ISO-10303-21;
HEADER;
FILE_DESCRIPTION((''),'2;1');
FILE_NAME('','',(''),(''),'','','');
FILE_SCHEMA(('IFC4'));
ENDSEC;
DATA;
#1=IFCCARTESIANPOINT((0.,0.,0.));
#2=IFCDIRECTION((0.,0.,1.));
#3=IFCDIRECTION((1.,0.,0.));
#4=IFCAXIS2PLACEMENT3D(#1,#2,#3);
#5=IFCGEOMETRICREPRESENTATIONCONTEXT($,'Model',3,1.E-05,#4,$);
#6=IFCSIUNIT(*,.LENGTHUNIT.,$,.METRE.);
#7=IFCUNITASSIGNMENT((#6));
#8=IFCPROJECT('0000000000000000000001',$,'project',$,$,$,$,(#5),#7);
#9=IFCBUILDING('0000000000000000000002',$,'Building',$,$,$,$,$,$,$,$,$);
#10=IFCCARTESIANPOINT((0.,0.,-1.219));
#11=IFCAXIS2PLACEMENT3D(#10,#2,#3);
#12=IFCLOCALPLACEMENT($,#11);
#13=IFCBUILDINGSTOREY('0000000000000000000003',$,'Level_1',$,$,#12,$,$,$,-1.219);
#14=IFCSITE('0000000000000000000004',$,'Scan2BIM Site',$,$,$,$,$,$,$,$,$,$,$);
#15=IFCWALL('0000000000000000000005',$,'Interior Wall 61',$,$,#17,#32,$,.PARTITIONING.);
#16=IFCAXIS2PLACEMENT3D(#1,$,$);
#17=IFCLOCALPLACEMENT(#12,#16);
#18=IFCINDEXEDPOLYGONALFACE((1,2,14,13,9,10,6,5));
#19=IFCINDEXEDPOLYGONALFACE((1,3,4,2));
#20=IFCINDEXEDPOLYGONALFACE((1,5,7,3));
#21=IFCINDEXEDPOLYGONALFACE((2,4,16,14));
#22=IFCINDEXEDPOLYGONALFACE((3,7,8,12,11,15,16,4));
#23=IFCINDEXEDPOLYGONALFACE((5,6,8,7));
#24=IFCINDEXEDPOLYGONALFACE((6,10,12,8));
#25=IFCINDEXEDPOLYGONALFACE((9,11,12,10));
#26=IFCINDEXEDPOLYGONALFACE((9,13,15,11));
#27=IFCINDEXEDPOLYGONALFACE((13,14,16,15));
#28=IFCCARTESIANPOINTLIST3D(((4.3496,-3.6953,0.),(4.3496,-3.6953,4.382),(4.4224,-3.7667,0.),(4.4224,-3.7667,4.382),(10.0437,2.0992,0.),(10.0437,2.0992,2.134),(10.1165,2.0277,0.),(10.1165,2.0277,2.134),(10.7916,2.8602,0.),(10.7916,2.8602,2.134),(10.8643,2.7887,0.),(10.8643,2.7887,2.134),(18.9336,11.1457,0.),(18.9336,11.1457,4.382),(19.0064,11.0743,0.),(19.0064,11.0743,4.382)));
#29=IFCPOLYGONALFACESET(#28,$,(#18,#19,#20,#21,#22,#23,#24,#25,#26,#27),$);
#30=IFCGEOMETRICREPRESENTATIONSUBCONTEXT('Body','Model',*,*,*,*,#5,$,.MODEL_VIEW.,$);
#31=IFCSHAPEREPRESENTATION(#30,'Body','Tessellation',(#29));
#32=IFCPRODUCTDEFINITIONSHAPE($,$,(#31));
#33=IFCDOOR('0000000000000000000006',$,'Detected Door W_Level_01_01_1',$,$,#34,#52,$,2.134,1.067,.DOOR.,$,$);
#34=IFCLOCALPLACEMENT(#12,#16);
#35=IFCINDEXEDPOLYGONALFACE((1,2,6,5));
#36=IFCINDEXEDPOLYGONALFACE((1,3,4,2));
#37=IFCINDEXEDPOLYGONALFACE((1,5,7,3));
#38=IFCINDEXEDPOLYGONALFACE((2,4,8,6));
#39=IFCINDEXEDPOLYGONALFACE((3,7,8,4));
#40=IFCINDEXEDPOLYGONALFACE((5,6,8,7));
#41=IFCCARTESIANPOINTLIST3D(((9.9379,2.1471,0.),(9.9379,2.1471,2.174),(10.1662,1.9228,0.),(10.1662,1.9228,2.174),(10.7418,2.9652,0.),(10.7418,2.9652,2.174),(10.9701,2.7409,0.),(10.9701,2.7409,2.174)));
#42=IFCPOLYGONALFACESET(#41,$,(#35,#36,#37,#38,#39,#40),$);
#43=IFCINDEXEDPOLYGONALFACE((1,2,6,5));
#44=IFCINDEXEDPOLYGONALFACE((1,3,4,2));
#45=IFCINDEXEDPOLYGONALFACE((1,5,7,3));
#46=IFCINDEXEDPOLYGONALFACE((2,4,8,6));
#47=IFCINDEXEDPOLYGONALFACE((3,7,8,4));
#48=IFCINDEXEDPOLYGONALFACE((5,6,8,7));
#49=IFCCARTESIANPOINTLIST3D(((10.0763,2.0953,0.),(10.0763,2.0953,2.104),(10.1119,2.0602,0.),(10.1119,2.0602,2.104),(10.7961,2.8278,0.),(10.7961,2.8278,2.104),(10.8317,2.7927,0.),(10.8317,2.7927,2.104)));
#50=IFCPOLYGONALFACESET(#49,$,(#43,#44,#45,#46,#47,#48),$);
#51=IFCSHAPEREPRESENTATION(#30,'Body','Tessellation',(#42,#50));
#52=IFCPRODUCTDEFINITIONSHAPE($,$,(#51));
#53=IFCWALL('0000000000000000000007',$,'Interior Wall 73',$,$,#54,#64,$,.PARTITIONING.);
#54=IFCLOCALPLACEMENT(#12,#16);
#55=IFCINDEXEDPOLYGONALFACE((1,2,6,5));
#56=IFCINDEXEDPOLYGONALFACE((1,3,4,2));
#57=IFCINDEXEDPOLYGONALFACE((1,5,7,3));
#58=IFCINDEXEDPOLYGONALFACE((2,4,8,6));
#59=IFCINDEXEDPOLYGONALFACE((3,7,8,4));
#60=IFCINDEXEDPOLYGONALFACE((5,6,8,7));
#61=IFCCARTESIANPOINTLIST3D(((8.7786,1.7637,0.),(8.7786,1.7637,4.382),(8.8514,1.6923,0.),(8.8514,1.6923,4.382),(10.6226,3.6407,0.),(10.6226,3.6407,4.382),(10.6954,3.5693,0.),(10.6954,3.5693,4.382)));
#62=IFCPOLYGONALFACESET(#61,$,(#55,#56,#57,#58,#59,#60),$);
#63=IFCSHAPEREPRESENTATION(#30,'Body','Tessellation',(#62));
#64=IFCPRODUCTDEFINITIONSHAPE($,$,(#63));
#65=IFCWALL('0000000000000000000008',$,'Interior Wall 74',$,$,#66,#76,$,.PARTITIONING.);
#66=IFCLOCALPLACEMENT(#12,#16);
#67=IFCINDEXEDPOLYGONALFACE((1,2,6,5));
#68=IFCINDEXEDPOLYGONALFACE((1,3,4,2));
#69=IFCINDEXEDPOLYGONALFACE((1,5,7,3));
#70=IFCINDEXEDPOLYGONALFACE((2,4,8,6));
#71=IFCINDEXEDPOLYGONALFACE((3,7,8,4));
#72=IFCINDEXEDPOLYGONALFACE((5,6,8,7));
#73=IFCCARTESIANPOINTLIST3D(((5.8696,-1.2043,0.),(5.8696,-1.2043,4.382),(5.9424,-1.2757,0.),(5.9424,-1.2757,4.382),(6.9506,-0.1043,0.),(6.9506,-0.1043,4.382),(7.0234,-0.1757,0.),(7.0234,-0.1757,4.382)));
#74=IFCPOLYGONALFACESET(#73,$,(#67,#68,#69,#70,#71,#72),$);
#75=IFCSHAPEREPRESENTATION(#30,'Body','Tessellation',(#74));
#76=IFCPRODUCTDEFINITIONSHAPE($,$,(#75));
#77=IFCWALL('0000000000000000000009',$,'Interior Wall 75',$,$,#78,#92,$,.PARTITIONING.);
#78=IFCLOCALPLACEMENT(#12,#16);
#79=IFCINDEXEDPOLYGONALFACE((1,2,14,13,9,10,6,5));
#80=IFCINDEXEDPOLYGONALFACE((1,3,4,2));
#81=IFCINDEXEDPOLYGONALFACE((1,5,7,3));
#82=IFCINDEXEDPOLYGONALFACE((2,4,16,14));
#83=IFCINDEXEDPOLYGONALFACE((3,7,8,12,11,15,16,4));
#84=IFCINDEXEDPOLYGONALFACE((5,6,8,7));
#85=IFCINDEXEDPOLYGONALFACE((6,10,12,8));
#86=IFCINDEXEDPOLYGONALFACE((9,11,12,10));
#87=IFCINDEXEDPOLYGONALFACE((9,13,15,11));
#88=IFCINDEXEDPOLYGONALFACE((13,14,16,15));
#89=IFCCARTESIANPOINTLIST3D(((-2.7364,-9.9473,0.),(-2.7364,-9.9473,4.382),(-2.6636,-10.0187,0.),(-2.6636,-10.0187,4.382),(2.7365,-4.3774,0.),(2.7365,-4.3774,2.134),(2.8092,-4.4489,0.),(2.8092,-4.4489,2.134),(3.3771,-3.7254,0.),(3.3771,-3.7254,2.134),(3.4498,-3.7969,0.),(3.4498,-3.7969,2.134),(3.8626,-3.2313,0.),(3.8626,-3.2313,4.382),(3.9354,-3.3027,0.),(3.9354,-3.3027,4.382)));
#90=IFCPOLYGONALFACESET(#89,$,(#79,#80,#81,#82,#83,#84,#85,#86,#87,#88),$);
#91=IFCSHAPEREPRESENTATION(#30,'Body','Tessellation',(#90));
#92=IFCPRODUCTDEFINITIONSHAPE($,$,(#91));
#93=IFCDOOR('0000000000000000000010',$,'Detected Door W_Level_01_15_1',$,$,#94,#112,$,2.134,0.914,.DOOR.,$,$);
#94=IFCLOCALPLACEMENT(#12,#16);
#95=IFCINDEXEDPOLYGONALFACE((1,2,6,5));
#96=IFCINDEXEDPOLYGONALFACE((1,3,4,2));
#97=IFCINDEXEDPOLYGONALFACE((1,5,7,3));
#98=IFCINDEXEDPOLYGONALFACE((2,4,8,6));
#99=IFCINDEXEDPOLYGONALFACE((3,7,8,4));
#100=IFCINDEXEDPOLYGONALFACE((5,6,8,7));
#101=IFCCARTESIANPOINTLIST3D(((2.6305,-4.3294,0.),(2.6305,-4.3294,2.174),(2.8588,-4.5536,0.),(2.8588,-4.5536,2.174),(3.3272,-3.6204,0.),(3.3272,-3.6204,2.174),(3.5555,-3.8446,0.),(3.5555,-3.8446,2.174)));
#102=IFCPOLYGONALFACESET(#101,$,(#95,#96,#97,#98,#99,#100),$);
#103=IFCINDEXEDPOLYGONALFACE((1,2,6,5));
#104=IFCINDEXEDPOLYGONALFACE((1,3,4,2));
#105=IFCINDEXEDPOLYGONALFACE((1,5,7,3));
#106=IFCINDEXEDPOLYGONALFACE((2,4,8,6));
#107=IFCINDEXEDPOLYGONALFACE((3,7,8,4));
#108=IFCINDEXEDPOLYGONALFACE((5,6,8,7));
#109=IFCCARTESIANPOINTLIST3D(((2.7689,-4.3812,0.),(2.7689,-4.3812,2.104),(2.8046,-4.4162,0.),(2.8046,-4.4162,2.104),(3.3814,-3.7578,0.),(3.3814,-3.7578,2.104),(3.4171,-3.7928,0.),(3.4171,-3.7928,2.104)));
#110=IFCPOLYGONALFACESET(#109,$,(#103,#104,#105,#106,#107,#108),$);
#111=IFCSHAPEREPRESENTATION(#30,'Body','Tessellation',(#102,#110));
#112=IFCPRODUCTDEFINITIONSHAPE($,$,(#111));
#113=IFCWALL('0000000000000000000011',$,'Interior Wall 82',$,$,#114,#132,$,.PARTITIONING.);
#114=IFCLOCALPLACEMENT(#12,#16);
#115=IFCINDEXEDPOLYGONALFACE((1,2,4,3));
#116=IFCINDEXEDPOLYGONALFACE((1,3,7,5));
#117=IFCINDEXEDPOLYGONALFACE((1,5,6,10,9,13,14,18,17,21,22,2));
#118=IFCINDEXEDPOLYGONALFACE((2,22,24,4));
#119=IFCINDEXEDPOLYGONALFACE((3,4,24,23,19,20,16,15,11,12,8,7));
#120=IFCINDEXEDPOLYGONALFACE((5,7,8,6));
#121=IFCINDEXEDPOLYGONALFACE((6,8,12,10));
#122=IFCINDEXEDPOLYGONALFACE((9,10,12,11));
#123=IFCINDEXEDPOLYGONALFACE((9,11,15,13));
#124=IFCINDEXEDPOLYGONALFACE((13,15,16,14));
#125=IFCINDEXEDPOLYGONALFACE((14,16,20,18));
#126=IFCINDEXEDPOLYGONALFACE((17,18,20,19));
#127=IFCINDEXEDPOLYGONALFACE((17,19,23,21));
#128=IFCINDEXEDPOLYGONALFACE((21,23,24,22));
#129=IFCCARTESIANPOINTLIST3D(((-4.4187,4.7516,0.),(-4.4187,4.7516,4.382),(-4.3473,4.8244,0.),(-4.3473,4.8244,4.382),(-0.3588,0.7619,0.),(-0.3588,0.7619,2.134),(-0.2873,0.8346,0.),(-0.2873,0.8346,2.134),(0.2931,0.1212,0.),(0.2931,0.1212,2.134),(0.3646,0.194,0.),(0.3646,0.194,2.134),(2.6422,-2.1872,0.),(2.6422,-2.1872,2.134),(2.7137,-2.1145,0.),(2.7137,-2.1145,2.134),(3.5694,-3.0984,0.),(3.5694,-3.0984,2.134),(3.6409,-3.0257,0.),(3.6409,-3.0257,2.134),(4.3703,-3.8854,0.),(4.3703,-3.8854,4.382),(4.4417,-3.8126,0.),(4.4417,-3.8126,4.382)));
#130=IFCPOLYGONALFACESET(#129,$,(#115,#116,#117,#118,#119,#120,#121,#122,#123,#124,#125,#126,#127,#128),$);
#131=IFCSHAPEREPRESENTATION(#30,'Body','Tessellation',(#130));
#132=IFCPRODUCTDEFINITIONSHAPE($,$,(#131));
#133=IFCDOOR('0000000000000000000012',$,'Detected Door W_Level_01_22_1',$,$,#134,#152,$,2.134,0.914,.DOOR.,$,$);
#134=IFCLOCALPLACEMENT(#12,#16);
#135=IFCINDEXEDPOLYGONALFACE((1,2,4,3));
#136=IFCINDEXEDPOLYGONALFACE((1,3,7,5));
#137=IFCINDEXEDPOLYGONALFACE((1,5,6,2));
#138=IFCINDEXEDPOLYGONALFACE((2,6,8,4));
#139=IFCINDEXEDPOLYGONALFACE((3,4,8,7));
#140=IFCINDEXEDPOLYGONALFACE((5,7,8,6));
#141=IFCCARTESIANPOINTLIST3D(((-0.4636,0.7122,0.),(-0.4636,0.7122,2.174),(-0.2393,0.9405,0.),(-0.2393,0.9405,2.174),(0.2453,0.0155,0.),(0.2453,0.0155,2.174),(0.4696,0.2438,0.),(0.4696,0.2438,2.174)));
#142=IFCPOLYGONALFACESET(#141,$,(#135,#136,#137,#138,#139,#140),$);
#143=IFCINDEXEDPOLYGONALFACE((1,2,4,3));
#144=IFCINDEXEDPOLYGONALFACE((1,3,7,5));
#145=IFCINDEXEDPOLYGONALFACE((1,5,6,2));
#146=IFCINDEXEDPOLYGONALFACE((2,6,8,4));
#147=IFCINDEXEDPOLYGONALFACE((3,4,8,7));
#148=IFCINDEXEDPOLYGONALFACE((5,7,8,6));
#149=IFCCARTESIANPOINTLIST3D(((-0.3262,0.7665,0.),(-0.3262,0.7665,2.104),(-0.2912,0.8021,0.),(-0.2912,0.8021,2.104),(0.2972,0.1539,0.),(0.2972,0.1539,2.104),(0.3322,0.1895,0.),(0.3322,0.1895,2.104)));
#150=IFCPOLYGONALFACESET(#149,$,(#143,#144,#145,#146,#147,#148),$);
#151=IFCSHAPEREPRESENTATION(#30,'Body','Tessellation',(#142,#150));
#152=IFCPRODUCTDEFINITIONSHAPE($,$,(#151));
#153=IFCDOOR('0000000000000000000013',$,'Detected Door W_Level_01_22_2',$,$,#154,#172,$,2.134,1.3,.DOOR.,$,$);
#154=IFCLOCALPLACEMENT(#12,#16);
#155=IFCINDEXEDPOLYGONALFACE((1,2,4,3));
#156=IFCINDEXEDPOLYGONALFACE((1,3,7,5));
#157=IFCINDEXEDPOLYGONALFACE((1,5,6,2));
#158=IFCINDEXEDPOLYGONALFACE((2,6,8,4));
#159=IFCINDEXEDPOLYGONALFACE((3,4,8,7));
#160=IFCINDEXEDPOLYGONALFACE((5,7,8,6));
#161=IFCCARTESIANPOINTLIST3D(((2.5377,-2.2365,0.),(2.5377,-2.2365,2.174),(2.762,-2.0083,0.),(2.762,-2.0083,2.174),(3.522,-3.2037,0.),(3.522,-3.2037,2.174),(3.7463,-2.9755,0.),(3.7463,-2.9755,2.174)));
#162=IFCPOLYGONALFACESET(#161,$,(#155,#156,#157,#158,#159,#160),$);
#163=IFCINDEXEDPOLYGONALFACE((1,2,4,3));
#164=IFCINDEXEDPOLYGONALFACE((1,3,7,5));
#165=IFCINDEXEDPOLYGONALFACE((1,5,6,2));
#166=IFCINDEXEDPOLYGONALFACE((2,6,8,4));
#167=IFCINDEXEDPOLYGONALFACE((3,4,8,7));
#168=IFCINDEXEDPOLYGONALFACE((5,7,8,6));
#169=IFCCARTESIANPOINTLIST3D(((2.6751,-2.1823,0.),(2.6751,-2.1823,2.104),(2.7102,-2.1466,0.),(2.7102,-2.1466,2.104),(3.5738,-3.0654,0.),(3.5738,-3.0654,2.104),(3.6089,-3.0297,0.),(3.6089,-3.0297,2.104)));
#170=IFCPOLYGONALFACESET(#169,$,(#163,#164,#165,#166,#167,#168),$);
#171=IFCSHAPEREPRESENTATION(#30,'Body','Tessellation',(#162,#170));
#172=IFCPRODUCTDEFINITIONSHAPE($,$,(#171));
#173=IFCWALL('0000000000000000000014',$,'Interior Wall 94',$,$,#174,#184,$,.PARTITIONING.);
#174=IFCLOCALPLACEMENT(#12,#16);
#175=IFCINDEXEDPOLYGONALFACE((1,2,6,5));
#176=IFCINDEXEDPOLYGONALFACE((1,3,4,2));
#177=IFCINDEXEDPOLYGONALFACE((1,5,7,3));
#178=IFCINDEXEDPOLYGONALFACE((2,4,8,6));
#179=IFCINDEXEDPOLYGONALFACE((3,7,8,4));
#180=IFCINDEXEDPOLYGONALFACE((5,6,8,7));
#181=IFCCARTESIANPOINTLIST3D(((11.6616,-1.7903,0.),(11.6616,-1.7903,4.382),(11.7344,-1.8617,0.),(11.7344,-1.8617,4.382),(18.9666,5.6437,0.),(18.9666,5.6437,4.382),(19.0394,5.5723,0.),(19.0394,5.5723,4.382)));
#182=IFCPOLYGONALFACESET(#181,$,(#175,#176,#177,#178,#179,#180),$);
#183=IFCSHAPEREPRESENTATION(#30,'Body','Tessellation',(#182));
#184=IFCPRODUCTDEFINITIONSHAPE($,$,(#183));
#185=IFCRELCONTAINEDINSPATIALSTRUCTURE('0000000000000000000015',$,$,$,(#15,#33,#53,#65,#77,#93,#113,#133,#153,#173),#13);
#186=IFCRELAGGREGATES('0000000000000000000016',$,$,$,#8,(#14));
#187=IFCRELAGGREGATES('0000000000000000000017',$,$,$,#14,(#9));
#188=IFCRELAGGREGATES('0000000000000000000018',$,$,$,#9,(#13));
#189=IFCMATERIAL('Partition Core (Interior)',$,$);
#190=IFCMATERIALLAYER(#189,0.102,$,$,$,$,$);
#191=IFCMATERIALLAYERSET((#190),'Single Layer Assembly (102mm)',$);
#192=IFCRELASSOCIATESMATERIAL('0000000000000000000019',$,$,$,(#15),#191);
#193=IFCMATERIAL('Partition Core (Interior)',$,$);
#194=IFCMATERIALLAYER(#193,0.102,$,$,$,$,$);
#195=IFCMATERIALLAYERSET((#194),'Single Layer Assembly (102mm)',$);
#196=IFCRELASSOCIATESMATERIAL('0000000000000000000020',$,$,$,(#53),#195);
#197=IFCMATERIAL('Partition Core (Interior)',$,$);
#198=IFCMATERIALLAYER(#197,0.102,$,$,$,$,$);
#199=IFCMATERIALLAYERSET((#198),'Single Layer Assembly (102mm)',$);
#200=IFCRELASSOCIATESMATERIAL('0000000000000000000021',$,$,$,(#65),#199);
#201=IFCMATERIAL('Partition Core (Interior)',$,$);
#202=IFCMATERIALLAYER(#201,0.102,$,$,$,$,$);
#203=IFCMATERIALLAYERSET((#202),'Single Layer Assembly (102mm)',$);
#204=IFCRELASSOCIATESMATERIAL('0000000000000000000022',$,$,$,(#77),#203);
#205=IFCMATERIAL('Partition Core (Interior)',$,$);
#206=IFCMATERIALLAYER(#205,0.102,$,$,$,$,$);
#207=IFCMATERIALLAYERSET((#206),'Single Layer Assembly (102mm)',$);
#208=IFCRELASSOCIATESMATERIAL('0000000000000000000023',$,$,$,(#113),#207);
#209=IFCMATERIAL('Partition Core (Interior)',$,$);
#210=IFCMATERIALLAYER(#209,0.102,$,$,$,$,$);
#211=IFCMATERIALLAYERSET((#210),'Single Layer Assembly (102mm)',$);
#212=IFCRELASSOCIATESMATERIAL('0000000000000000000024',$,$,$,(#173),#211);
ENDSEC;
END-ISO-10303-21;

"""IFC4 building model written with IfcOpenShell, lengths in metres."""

from ifc_helpers import new_model, si_unit, frame, origin, origin_with_axes, place, context, subcontext, project, spatial, rectangle, extrude, material, layer, layer_set, element, fill, save


model = new_model("IFC4")

# Units and contexts
model_context = context("Model", 3, precision=1e-05, world=origin_with_axes())
body_context = subcontext(model_context, "Body", "Model", "MODEL_VIEW")
ifc_project = project(units=[si_unit("LENGTHUNIT", "METRE")], contexts=[model_context])

# Site, building, storey
site = spatial("IfcSite", under=ifc_project, Name="Scan2BIM Site")
building = spatial("IfcBuilding", under=site, Name="Building")
storey_placement = place(None, frame((0.0, 0.0, -1.219), z_axis=(0.0, 0.0, 1.0), x_axis=(1.0, 0.0, 0.0)))
storey = spatial("IfcBuildingStorey", under=building, at=storey_placement, Name="Level_1", Elevation=-1.219)

# Wall, opening, door
ifc_material_1 = material(Name="Partition Core (Interior)")
ifc_layer_1 = layer(ifc_material_1, 0.102)
ifc_layer_set_1 = layer_set([ifc_layer_1], Name="Single Layer Assembly (102mm)")
wall_1_placement = place(storey_placement, frame((11.678, 3.6895, 0.0), z_axis=(0.0, 0.0, 1.0), x_axis=(-0.700904, -0.713255, 0.0)))
wall_1 = element("IfcWall", 1, at=wall_1_placement, inside=storey, material=ifc_layer_set_1, Name="Interior Wall 61", PredefinedType="PARTITIONING", context=body_context, shape_type="SweptSolid", body=[
    extrude(rectangle(XDim=20.8074, YDim=0.102), origin(), (0.0, 0.0, 1.0), 4.382),
])
opening_1_placement = place(None, frame((10.454, 2.444, -1.219), z_axis=(0.0, 0.0, 1.0), x_axis=(-0.700904, -0.713255, 0.0)))
opening_1 = element("IfcOpeningElement", 2, at=opening_1_placement, cuts=wall_1, PredefinedType="OPENING", context=body_context, shape_type="SweptSolid", body=[
    extrude(rectangle(XDim=1.067, YDim=0.202), origin(), (0.0, 0.0, 1.0), 2.134),
])
door_1_placement = place(opening_1_placement, frame((0.0, 0.0, 0.0), z_axis=(0.0, 0.0, 1.0), x_axis=(1.0, 0.0, 0.0)))
door_1 = element("IfcDoor", 3, at=door_1_placement, inside=storey, Name="Detected Door W_Level_01_01_1", OverallHeight=2.134, OverallWidth=1.067, PredefinedType="DOOR", context=body_context, shape_type="SweptSolid", body=[
    extrude(rectangle(XDim=1.147, YDim=0.32), origin(), (0.0, 0.0, 1.0), 2.174),
    extrude(rectangle(XDim=1.027, YDim=0.05), origin(), (0.0, 0.0, 1.0), 2.104),
])
fill(opening_1, door_1)

# Walls
ifc_material_2 = material(Name="Partition Core (Interior)")
ifc_layer_2 = layer(ifc_material_2, 0.102)
ifc_layer_set_2 = layer_set([ifc_layer_2], Name="Single Layer Assembly (102mm)")
wall_2_placement = place(storey_placement, frame((9.737, 2.6665, 0.0), z_axis=(0.0, 0.0, 1.0), x_axis=(-0.700808, -0.71335, 0.0)))
element("IfcWall", 4, at=wall_2_placement, inside=storey, material=ifc_layer_set_2, Name="Interior Wall 73", PredefinedType="PARTITIONING", context=body_context, shape_type="SweptSolid", body=[
    extrude(rectangle(XDim=2.6312, YDim=0.102), origin(), (0.0, 0.0, 1.0), 4.382),
])
ifc_material_3 = material(Name="Partition Core (Interior)")
ifc_layer_3 = layer(ifc_material_3, 0.102)
ifc_layer_set_3 = layer_set([ifc_layer_3], Name="Single Layer Assembly (102mm)")
wall_3_placement = place(storey_placement, frame((6.4465, -0.69, 0.0), z_axis=(0.0, 0.0, 1.0), x_axis=(-0.70092, -0.71324, 0.0)))
element("IfcWall", 5, at=wall_3_placement, inside=storey, material=ifc_layer_set_3, Name="Interior Wall 74", PredefinedType="PARTITIONING", context=body_context, shape_type="SweptSolid", body=[
    extrude(rectangle(XDim=1.5423, YDim=0.102), origin(), (0.0, 0.0, 1.0), 4.382),
])

# Wall, opening, door
ifc_material_4 = material(Name="Partition Core (Interior)")
ifc_layer_4 = layer(ifc_material_4, 0.102)
ifc_layer_set_4 = layer_set([ifc_layer_4], Name="Single Layer Assembly (102mm)")
wall_4_placement = place(storey_placement, frame((0.5995, -6.625, 0.0), z_axis=(0.0, 0.0, 1.0), x_axis=(-0.700866, -0.713293, 0.0)))
wall_4 = element("IfcWall", 6, at=wall_4_placement, inside=storey, material=ifc_layer_set_4, Name="Interior Wall 75", PredefinedType="PARTITIONING", context=body_context, shape_type="SweptSolid", body=[
    extrude(rectangle(XDim=9.4155, YDim=0.102), origin(), (0.0, 0.0, 1.0), 4.382),
])
opening_2_placement = place(None, frame((3.093, -4.087, -1.219), z_axis=(0.0, 0.0, 1.0), x_axis=(-0.700866, -0.713293, 0.0)))
opening_2 = element("IfcOpeningElement", 7, at=opening_2_placement, cuts=wall_4, PredefinedType="OPENING", context=body_context, shape_type="SweptSolid", body=[
    extrude(rectangle(XDim=0.914, YDim=0.202), origin(), (0.0, 0.0, 1.0), 2.134),
])
door_2_placement = place(opening_2_placement, frame((0.0, 0.0, 0.0), z_axis=(0.0, 0.0, 1.0), x_axis=(1.0, 0.0, 0.0)))
door_2 = element("IfcDoor", 8, at=door_2_placement, inside=storey, Name="Detected Door W_Level_01_15_1", OverallHeight=2.134, OverallWidth=0.914, PredefinedType="DOOR", context=body_context, shape_type="SweptSolid", body=[
    extrude(rectangle(XDim=0.994, YDim=0.32), origin(), (0.0, 0.0, 1.0), 2.174),
    extrude(rectangle(XDim=0.874, YDim=0.05), origin(), (0.0, 0.0, 1.0), 2.104),
])
fill(opening_2, door_2)

# Wall, openings, doors
ifc_material_5 = material(Name="Partition Core (Interior)")
ifc_layer_5 = layer(ifc_material_5, 0.102)
ifc_layer_set_5 = layer_set([ifc_layer_5], Name="Single Layer Assembly (102mm)")
wall_5_placement = place(storey_placement, frame((0.0115, 0.4695, 0.0), z_axis=(0.0, 0.0, 1.0), x_axis=(0.713247, -0.700912, 0.0)))
wall_5 = element("IfcWall", 9, at=wall_5_placement, inside=storey, material=ifc_layer_set_5, Name="Interior Wall 82", PredefinedType="PARTITIONING", context=body_context, shape_type="SweptSolid", body=[
    extrude(rectangle(XDim=12.3225, YDim=0.102), origin(), (0.0, 0.0, 1.0), 4.382),
])
opening_3_placement = place(None, frame((0.003, 0.478, -1.219), z_axis=(0.0, 0.0, 1.0), x_axis=(0.713247, -0.700912, 0.0)))
opening_3 = element("IfcOpeningElement", 10, at=opening_3_placement, cuts=wall_5, PredefinedType="OPENING", context=body_context, shape_type="SweptSolid", body=[
    extrude(rectangle(XDim=0.914, YDim=0.202), origin(), (0.0, 0.0, 1.0), 2.134),
])
opening_4_placement = place(None, frame((3.142, -2.606, -1.219), z_axis=(0.0, 0.0, 1.0), x_axis=(0.713247, -0.700912, 0.0)))
opening_4 = element("IfcOpeningElement", 11, at=opening_4_placement, cuts=wall_5, PredefinedType="OPENING", context=body_context, shape_type="SweptSolid", body=[
    extrude(rectangle(XDim=1.3, YDim=0.202), origin(), (0.0, 0.0, 1.0), 2.134),
])
door_3_placement = place(opening_3_placement, frame((0.0, 0.0, 0.0), z_axis=(0.0, 0.0, 1.0), x_axis=(1.0, 0.0, 0.0)))
door_3 = element("IfcDoor", 12, at=door_3_placement, inside=storey, Name="Detected Door W_Level_01_22_1", OverallHeight=2.134, OverallWidth=0.914, PredefinedType="DOOR", context=body_context, shape_type="SweptSolid", body=[
    extrude(rectangle(XDim=0.994, YDim=0.32), origin(), (0.0, 0.0, 1.0), 2.174),
    extrude(rectangle(XDim=0.874, YDim=0.05), origin(), (0.0, 0.0, 1.0), 2.104),
])
fill(opening_3, door_3)
door_4_placement = place(opening_4_placement, frame((0.0, 0.0, 0.0), z_axis=(0.0, 0.0, 1.0), x_axis=(1.0, 0.0, 0.0)))
door_4 = element("IfcDoor", 13, at=door_4_placement, inside=storey, Name="Detected Door W_Level_01_22_2", OverallHeight=2.134, OverallWidth=1.3, PredefinedType="DOOR", context=body_context, shape_type="SweptSolid", body=[
    extrude(rectangle(XDim=1.38, YDim=0.32), origin(), (0.0, 0.0, 1.0), 2.174),
    extrude(rectangle(XDim=1.26, YDim=0.05), origin(), (0.0, 0.0, 1.0), 2.104),
])
fill(opening_4, door_4)

# Wall
ifc_material_6 = material(Name="Partition Core (Interior)")
ifc_layer_6 = layer(ifc_material_6, 0.102)
ifc_layer_set_6 = layer_set([ifc_layer_6], Name="Single Layer Assembly (102mm)")
wall_6_placement = place(storey_placement, frame((15.3505, 1.891, 0.0), z_axis=(0.0, 0.0, 1.0), x_axis=(-0.700891, -0.713268, 0.0)))
element("IfcWall", 14, at=wall_6_placement, inside=storey, material=ifc_layer_set_6, Name="Interior Wall 94", PredefinedType="PARTITIONING", context=body_context, shape_type="SweptSolid", body=[
    extrude(rectangle(XDim=10.4224, YDim=0.102), origin(), (0.0, 0.0, 1.0), 4.382),
])

save(model, "model.ifc")
